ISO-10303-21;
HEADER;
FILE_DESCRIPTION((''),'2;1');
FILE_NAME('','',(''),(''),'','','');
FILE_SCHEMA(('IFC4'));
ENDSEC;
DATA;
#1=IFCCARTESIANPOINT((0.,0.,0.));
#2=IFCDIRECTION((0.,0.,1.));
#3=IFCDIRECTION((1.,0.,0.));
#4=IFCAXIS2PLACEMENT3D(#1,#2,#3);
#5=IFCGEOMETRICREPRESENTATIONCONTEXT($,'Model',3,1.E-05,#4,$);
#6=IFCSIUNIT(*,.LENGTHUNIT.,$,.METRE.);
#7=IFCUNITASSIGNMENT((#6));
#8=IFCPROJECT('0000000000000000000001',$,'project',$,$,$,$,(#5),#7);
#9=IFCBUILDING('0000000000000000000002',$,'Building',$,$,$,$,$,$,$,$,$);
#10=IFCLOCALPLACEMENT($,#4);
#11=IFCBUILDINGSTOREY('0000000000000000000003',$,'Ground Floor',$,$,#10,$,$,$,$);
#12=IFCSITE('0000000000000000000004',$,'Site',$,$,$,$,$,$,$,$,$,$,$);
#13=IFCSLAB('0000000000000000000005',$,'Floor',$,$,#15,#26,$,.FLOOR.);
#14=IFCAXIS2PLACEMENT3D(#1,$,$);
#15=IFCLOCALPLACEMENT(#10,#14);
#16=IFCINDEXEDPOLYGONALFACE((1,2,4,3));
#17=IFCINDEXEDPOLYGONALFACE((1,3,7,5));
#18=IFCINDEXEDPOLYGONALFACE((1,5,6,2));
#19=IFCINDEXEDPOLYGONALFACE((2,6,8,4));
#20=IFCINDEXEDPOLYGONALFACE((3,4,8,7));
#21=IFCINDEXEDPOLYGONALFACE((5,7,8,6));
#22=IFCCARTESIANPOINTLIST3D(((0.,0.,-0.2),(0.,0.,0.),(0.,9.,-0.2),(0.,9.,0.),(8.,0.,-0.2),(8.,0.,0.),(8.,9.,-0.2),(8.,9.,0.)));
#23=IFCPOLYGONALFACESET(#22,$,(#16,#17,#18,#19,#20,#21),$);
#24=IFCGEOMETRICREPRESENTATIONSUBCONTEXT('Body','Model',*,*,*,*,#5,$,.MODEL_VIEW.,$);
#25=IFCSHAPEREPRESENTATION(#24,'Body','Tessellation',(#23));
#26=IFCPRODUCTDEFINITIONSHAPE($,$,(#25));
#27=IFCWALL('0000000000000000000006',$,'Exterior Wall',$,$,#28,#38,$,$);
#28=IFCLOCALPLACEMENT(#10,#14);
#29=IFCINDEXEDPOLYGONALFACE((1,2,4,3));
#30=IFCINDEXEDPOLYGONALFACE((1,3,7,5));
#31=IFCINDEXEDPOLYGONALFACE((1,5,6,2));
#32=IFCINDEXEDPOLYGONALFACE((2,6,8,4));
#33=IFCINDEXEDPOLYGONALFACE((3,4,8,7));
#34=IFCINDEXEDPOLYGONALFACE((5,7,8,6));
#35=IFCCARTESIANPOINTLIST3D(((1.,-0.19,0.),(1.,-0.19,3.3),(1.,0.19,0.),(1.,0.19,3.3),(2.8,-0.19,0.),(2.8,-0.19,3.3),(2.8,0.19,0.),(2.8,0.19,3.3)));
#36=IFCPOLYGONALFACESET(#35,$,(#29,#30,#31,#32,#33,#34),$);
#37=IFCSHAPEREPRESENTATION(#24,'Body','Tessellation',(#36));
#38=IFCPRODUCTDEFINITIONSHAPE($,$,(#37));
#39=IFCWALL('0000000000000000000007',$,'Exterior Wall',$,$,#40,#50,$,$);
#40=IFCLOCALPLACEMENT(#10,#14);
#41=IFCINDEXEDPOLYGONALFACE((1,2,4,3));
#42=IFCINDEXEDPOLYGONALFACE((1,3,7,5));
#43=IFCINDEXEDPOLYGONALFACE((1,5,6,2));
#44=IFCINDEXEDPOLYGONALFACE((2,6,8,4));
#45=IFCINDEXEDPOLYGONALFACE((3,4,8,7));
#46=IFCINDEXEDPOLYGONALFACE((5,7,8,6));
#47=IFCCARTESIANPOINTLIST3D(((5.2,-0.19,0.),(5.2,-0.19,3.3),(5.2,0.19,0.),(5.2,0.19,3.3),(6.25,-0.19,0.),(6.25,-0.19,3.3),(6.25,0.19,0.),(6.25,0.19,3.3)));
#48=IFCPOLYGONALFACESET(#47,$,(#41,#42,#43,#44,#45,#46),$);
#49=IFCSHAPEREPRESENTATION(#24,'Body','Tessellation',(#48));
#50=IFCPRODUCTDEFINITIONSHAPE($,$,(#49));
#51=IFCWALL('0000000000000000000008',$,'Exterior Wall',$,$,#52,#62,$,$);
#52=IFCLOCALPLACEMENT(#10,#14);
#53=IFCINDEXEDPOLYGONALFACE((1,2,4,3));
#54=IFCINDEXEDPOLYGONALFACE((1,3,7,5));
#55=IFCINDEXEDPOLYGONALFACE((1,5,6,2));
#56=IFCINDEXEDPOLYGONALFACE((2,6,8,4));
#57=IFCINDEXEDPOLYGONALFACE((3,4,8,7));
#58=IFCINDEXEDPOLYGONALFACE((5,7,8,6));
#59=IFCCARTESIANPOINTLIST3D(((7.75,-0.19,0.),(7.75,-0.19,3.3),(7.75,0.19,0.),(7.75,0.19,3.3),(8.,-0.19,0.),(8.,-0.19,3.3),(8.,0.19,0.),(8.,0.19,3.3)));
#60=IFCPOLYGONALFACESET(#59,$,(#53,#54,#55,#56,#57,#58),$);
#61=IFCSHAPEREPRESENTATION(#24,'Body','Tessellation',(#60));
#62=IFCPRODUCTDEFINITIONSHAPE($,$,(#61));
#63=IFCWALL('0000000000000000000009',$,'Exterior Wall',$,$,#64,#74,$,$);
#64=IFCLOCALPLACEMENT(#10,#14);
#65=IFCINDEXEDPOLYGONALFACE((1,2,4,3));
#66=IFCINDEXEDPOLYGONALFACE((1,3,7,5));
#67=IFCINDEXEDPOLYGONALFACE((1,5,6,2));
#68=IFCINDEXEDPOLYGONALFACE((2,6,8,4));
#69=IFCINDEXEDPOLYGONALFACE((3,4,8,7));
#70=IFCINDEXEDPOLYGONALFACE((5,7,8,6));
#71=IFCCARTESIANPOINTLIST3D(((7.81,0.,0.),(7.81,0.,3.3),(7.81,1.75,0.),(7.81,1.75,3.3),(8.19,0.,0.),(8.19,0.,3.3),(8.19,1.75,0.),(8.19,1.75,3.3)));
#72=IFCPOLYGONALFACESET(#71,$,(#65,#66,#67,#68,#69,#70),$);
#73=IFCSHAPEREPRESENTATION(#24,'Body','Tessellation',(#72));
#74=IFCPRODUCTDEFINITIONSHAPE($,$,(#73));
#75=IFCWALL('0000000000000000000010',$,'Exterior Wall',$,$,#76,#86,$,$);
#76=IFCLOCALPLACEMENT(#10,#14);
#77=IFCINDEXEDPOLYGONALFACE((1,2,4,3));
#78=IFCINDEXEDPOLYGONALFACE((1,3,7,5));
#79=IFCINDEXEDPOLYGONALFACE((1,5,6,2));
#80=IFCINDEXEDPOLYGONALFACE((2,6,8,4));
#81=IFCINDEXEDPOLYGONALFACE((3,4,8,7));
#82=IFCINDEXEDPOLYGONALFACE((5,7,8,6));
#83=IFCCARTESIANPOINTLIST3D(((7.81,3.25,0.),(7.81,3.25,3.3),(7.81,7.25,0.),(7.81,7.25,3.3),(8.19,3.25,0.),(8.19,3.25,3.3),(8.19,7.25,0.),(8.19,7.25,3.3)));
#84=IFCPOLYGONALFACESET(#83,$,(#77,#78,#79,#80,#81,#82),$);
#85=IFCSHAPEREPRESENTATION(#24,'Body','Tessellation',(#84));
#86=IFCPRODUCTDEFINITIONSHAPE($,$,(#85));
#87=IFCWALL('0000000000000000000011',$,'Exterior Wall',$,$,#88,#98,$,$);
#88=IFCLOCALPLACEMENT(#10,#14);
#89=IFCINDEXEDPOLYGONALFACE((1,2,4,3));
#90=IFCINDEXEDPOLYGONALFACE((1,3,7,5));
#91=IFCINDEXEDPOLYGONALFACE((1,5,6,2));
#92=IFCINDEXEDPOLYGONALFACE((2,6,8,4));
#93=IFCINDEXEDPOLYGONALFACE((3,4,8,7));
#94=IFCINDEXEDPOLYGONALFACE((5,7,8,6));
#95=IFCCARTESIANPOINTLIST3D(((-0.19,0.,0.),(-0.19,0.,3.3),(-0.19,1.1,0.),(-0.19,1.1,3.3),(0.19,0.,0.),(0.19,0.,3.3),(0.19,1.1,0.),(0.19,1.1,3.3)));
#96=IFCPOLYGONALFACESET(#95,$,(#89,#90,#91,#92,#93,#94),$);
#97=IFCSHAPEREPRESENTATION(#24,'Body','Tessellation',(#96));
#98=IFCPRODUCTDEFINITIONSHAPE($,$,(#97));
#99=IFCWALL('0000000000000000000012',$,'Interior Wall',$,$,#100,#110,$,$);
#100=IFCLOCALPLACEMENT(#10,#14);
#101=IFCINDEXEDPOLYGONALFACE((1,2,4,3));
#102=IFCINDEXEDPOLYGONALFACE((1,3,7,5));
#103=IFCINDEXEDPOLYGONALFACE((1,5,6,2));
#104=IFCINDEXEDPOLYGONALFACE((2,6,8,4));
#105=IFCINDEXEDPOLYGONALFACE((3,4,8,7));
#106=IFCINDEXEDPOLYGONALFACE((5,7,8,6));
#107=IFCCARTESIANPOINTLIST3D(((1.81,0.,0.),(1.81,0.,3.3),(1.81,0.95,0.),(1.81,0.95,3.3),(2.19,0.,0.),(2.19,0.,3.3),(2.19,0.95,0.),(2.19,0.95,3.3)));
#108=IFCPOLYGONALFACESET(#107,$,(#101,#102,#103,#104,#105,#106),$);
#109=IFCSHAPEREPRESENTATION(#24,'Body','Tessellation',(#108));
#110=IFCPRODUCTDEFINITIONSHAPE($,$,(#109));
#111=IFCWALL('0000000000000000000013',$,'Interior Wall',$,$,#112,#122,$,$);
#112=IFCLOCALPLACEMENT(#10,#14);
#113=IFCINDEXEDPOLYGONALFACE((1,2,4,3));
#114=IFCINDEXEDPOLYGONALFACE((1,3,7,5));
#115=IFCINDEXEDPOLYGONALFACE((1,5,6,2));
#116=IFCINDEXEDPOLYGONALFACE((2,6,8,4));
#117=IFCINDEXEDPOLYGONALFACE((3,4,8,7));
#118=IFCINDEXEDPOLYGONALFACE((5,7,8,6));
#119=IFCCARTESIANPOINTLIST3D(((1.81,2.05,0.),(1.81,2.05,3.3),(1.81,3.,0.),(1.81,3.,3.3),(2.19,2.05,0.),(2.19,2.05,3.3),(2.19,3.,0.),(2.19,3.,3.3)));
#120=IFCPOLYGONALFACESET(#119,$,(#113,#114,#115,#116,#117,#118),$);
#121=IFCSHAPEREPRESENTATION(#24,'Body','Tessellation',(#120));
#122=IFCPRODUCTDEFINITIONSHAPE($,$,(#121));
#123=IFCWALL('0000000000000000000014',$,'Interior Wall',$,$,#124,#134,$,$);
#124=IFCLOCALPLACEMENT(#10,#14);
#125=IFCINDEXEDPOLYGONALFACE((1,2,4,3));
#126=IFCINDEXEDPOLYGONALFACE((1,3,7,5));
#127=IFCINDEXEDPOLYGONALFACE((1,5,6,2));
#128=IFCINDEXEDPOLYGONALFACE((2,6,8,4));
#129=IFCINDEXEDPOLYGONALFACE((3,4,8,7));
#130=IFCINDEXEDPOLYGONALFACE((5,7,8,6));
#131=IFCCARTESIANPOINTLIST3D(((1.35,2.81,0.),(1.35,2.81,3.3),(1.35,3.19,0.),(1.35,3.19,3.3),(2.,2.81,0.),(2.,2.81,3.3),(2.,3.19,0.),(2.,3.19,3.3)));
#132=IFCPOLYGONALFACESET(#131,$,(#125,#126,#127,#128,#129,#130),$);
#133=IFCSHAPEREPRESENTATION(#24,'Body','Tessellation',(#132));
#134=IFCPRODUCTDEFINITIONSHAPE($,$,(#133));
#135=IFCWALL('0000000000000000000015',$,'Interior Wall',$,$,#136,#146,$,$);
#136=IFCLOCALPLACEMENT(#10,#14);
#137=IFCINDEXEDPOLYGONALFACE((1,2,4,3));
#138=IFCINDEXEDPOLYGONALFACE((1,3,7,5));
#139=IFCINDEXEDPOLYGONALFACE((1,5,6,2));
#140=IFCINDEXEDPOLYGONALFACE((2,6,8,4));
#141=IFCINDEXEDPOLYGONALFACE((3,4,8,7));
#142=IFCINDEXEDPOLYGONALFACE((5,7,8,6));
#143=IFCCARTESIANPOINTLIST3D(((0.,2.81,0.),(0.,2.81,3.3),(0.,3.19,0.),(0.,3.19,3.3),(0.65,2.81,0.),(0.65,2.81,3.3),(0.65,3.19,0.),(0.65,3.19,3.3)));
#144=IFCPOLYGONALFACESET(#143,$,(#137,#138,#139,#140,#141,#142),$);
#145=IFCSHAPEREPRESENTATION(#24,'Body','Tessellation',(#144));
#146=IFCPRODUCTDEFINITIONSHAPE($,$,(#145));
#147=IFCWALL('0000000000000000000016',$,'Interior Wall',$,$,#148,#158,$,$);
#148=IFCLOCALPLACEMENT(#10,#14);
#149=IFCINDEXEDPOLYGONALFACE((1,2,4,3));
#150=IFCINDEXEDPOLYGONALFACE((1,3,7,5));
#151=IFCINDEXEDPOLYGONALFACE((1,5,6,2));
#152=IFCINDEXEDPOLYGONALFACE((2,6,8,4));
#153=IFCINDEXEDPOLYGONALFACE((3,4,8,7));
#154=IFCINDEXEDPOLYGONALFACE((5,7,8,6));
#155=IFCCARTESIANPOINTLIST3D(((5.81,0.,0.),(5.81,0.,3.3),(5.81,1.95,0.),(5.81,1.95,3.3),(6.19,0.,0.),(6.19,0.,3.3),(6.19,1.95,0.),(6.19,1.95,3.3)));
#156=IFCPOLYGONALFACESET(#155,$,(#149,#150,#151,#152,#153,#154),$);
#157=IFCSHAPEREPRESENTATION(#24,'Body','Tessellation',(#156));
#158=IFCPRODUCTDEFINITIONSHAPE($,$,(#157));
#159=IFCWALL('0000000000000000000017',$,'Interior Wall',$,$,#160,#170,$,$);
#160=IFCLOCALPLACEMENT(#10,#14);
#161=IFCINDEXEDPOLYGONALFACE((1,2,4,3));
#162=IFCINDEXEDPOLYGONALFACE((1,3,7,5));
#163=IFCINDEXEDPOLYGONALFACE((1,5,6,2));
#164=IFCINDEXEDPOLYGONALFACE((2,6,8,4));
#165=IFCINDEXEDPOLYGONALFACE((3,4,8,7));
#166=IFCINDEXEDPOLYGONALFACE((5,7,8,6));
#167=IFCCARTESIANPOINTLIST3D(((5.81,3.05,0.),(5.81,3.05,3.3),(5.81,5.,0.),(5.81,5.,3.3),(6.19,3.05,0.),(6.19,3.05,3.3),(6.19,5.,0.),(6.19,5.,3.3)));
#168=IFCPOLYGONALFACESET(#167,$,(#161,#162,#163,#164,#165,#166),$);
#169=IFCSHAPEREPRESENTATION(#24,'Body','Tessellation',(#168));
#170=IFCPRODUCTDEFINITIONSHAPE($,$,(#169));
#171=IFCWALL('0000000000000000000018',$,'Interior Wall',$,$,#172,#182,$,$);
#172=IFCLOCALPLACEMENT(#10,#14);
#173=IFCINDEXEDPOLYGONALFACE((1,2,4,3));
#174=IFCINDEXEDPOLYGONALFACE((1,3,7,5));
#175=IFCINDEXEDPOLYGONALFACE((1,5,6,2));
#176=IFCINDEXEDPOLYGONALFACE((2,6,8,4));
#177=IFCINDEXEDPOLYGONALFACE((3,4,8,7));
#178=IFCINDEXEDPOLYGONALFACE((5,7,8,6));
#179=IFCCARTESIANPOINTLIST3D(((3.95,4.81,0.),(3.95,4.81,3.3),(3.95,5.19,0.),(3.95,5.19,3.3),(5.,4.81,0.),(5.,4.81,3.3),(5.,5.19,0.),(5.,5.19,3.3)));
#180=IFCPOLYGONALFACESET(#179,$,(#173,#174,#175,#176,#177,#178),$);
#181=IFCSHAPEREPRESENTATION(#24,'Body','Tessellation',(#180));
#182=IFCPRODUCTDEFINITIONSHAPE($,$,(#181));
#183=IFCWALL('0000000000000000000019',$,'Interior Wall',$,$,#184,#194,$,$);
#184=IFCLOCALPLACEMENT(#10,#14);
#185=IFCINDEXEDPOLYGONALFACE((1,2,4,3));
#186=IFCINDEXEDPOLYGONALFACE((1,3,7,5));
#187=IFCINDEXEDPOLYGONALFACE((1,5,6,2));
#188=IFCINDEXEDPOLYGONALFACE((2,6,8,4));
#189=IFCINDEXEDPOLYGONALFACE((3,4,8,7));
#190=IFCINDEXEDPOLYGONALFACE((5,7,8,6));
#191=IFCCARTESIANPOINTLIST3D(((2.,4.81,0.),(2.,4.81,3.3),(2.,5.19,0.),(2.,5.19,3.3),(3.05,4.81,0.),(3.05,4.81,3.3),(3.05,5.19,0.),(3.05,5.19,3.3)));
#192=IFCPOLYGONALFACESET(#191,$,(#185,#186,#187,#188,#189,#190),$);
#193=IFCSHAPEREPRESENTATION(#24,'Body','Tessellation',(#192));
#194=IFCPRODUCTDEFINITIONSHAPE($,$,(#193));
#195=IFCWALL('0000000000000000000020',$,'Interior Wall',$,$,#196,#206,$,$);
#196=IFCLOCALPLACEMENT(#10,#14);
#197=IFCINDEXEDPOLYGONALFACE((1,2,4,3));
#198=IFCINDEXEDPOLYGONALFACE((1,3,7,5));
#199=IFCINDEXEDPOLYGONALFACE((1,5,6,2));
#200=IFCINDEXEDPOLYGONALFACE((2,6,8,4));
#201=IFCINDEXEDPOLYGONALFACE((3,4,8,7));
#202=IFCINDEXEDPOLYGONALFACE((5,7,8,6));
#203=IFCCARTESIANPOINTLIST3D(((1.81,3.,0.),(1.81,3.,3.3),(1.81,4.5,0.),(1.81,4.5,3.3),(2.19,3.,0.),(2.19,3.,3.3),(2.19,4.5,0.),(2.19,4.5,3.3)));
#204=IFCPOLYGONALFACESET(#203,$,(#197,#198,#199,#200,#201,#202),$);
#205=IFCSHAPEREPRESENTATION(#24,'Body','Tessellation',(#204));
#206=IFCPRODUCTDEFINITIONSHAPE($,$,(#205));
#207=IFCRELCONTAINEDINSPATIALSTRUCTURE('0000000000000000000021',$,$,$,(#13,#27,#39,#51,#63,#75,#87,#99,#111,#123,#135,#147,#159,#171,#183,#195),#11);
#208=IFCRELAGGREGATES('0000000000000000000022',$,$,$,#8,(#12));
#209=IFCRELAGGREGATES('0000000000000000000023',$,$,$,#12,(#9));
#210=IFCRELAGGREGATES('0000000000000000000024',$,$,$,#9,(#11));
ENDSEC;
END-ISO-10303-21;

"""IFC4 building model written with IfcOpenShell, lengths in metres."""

from ifc_helpers import new_model, si_unit, frame, origin_with_axes, place, context, subcontext, project, spatial, indexed_curve, outline, extrude, element, save


model = new_model("IFC4")

# Units and contexts
model_context = context("Model", 3, precision=1e-05, world=origin_with_axes())
body_context = subcontext(model_context, "Body", "Model", "MODEL_VIEW")
ifc_project = project(units=[si_unit("LENGTHUNIT", "METRE")], contexts=[model_context])

# Site, building, storey
site = spatial("IfcSite", under=ifc_project, Name="Site")
building = spatial("IfcBuilding", under=site, Name="Building")
storey_placement = place(None, origin_with_axes())
storey = spatial("IfcBuildingStorey", under=building, at=storey_placement, Name="Ground Floor")

# Slab
slab_placement = place(storey_placement, frame((0.0, 0.0, -0.2), z_axis=(0.0, 0.0, 1.0), x_axis=(1.0, 0.0, 0.0)))
element("IfcSlab", 1, at=slab_placement, inside=storey, Name="Floor", PredefinedType="FLOOR", context=body_context, shape_type="SweptSolid", body=[
    extrude(outline(indexed_curve([(0.0, 0.0), (8.0, 0.0), (8.0, 9.0), (0.0, 9.0)])), None, (0.0, 0.0, 1.0), 0.2),
])

# Walls
wall_1_placement = place(storey_placement, frame((1.0, 0.0, 0.0), z_axis=(0.0, 0.0, 1.0), x_axis=(1.0, 0.0, 0.0)))
element("IfcWall", 2, at=wall_1_placement, inside=storey, Name="Exterior Wall", context=body_context, shape_type="SweptSolid", body=[
    extrude(outline(indexed_curve([(0.0, 0.0), (0.0, 0.38), (1.8, 0.38), (1.8, 0.0), (0.0, 0.0)], self_intersect=False)), frame((0.0, -0.19, 0.0), z_axis=(0.0, 0.0, 1.0), x_axis=(1.0, 0.0, 0.0)), (0.0, 0.0, 1.0), 3.3),
])
wall_2_placement = place(storey_placement, frame((5.2, 0.0, 0.0), z_axis=(0.0, 0.0, 1.0), x_axis=(1.0, 0.0, 0.0)))
element("IfcWall", 3, at=wall_2_placement, inside=storey, Name="Exterior Wall", context=body_context, shape_type="SweptSolid", body=[
    extrude(outline(indexed_curve([(0.0, 0.0), (0.0, 0.38), (1.05, 0.38), (1.05, 0.0), (0.0, 0.0)], self_intersect=False)), frame((0.0, -0.19, 0.0), z_axis=(0.0, 0.0, 1.0), x_axis=(1.0, 0.0, 0.0)), (0.0, 0.0, 1.0), 3.3),
])
wall_3_placement = place(storey_placement, frame((7.75, 0.0, 0.0), z_axis=(0.0, 0.0, 1.0), x_axis=(1.0, 0.0, 0.0)))
element("IfcWall", 4, at=wall_3_placement, inside=storey, Name="Exterior Wall", context=body_context, shape_type="SweptSolid", body=[
    extrude(outline(indexed_curve([(0.0, 0.0), (0.0, 0.38), (0.25, 0.38), (0.25, 0.0), (0.0, 0.0)], self_intersect=False)), frame((0.0, -0.19, 0.0), z_axis=(0.0, 0.0, 1.0), x_axis=(1.0, 0.0, 0.0)), (0.0, 0.0, 1.0), 3.3),
])
wall_4_placement = place(storey_placement, frame((8.0, 0.0, 0.0), z_axis=(0.0, 0.0, 1.0), x_axis=(0.0, 1.0, 0.0)))
element("IfcWall", 5, at=wall_4_placement, inside=storey, Name="Exterior Wall", context=body_context, shape_type="SweptSolid", body=[
    extrude(outline(indexed_curve([(0.0, 0.0), (0.0, 0.38), (1.75, 0.38), (1.75, 0.0), (0.0, 0.0)], self_intersect=False)), frame((0.0, -0.19, 0.0), z_axis=(0.0, 0.0, 1.0), x_axis=(1.0, 0.0, 0.0)), (0.0, 0.0, 1.0), 3.3),
])
wall_5_placement = place(storey_placement, frame((8.0, 3.25, 0.0), z_axis=(0.0, 0.0, 1.0), x_axis=(0.0, 1.0, 0.0)))
element("IfcWall", 6, at=wall_5_placement, inside=storey, Name="Exterior Wall", context=body_context, shape_type="SweptSolid", body=[
    extrude(outline(indexed_curve([(0.0, 0.0), (0.0, 0.38), (4.0, 0.38), (4.0, 0.0), (0.0, 0.0)], self_intersect=False)), frame((0.0, -0.19, 0.0), z_axis=(0.0, 0.0, 1.0), x_axis=(1.0, 0.0, 0.0)), (0.0, 0.0, 1.0), 3.3),
])
wall_6_placement = place(storey_placement, frame((0.0, 1.1, 0.0), z_axis=(0.0, 0.0, 1.0), x_axis=(0.0, -1.0, 0.0)))
element("IfcWall", 7, at=wall_6_placement, inside=storey, Name="Exterior Wall", context=body_context, shape_type="SweptSolid", body=[
    extrude(outline(indexed_curve([(0.0, 0.0), (0.0, 0.38), (1.1, 0.38), (1.1, 0.0), (0.0, 0.0)], self_intersect=False)), frame((0.0, -0.19, 0.0), z_axis=(0.0, 0.0, 1.0), x_axis=(1.0, 0.0, 0.0)), (0.0, 0.0, 1.0), 3.3),
])
wall_7_placement = place(storey_placement, frame((2.0, 0.0, 0.0), z_axis=(0.0, 0.0, 1.0), x_axis=(0.0, 1.0, 0.0)))
element("IfcWall", 8, at=wall_7_placement, inside=storey, Name="Interior Wall", context=body_context, shape_type="SweptSolid", body=[
    extrude(outline(indexed_curve([(0.0, 0.0), (0.0, 0.38), (0.95, 0.38), (0.95, 0.0), (0.0, 0.0)], self_intersect=False)), frame((0.0, -0.19, 0.0), z_axis=(0.0, 0.0, 1.0), x_axis=(1.0, 0.0, 0.0)), (0.0, 0.0, 1.0), 3.3),
])
wall_8_placement = place(storey_placement, frame((2.0, 2.05, 0.0), z_axis=(0.0, 0.0, 1.0), x_axis=(0.0, 1.0, 0.0)))
element("IfcWall", 9, at=wall_8_placement, inside=storey, Name="Interior Wall", context=body_context, shape_type="SweptSolid", body=[
    extrude(outline(indexed_curve([(0.0, 0.0), (0.0, 0.38), (0.95, 0.38), (0.95, 0.0), (0.0, 0.0)], self_intersect=False)), frame((0.0, -0.19, 0.0), z_axis=(0.0, 0.0, 1.0), x_axis=(1.0, 0.0, 0.0)), (0.0, 0.0, 1.0), 3.3),
])
for number, where, z_axis, x_axis, name in (
    (10, (2.0, 3.0, 0.0), (0.0, 0.0, 1.0), (-1.0, 0.0, 0.0), "Interior Wall"),
    (11, (0.65, 3.0, 0.0), (0.0, 0.0, 1.0), (-1.0, 0.0, 0.0), "Interior Wall"),
):
    element("IfcWall", number, at=place(storey_placement, frame(where, z_axis=z_axis, x_axis=x_axis)), inside=storey, Name=name, context=body_context, shape_type="SweptSolid", body=[
        extrude(outline(indexed_curve([(0.0, 0.0), (0.0, 0.38), (0.65, 0.38), (0.65, 0.0), (0.0, 0.0)], self_intersect=False)), frame((0.0, -0.19, 0.0), z_axis=(0.0, 0.0, 1.0), x_axis=(1.0, 0.0, 0.0)), (0.0, 0.0, 1.0), 3.3),
    ])
wall_9_placement = place(storey_placement, frame((6.0, 0.0, 0.0), z_axis=(0.0, 0.0, 1.0), x_axis=(0.0, 1.0, 0.0)))
element("IfcWall", 12, at=wall_9_placement, inside=storey, Name="Interior Wall", context=body_context, shape_type="SweptSolid", body=[
    extrude(outline(indexed_curve([(0.0, 0.0), (0.0, 0.38), (1.95, 0.38), (1.95, 0.0), (0.0, 0.0)], self_intersect=False)), frame((0.0, -0.19, 0.0), z_axis=(0.0, 0.0, 1.0), x_axis=(1.0, 0.0, 0.0)), (0.0, 0.0, 1.0), 3.3),
])
wall_10_placement = place(storey_placement, frame((6.0, 3.05, 0.0), z_axis=(0.0, 0.0, 1.0), x_axis=(0.0, 1.0, 0.0)))
element("IfcWall", 13, at=wall_10_placement, inside=storey, Name="Interior Wall", context=body_context, shape_type="SweptSolid", body=[
    extrude(outline(indexed_curve([(0.0, 0.0), (0.0, 0.38), (1.95, 0.38), (1.95, 0.0), (0.0, 0.0)], self_intersect=False)), frame((0.0, -0.19, 0.0), z_axis=(0.0, 0.0, 1.0), x_axis=(1.0, 0.0, 0.0)), (0.0, 0.0, 1.0), 3.3),
])
for number, where, z_axis, x_axis, name in (
    (14, (5.0, 5.0, 0.0), (0.0, 0.0, 1.0), (-1.0, 0.0, 0.0), "Interior Wall"),
    (15, (3.05, 5.0, 0.0), (0.0, 0.0, 1.0), (-1.0, 0.0, 0.0), "Interior Wall"),
):
    element("IfcWall", number, at=place(storey_placement, frame(where, z_axis=z_axis, x_axis=x_axis)), inside=storey, Name=name, context=body_context, shape_type="SweptSolid", body=[
        extrude(outline(indexed_curve([(0.0, 0.0), (0.0, 0.38), (1.05, 0.38), (1.05, 0.0), (0.0, 0.0)], self_intersect=False)), frame((0.0, -0.19, 0.0), z_axis=(0.0, 0.0, 1.0), x_axis=(1.0, 0.0, 0.0)), (0.0, 0.0, 1.0), 3.3),
    ])
wall_11_placement = place(storey_placement, frame((2.0, 4.5, 0.0), z_axis=(0.0, 0.0, 1.0), x_axis=(0.0, -1.0, 0.0)))
element("IfcWall", 16, at=wall_11_placement, inside=storey, Name="Interior Wall", context=body_context, shape_type="SweptSolid", body=[
    extrude(outline(indexed_curve([(0.0, 0.0), (0.0, 0.38), (1.5, 0.38), (1.5, 0.0), (0.0, 0.0)], self_intersect=False)), frame((0.0, -0.19, 0.0), z_axis=(0.0, 0.0, 1.0), x_axis=(1.0, 0.0, 0.0)), (0.0, 0.0, 1.0), 3.3),
])

save(model, "model.ifc")
